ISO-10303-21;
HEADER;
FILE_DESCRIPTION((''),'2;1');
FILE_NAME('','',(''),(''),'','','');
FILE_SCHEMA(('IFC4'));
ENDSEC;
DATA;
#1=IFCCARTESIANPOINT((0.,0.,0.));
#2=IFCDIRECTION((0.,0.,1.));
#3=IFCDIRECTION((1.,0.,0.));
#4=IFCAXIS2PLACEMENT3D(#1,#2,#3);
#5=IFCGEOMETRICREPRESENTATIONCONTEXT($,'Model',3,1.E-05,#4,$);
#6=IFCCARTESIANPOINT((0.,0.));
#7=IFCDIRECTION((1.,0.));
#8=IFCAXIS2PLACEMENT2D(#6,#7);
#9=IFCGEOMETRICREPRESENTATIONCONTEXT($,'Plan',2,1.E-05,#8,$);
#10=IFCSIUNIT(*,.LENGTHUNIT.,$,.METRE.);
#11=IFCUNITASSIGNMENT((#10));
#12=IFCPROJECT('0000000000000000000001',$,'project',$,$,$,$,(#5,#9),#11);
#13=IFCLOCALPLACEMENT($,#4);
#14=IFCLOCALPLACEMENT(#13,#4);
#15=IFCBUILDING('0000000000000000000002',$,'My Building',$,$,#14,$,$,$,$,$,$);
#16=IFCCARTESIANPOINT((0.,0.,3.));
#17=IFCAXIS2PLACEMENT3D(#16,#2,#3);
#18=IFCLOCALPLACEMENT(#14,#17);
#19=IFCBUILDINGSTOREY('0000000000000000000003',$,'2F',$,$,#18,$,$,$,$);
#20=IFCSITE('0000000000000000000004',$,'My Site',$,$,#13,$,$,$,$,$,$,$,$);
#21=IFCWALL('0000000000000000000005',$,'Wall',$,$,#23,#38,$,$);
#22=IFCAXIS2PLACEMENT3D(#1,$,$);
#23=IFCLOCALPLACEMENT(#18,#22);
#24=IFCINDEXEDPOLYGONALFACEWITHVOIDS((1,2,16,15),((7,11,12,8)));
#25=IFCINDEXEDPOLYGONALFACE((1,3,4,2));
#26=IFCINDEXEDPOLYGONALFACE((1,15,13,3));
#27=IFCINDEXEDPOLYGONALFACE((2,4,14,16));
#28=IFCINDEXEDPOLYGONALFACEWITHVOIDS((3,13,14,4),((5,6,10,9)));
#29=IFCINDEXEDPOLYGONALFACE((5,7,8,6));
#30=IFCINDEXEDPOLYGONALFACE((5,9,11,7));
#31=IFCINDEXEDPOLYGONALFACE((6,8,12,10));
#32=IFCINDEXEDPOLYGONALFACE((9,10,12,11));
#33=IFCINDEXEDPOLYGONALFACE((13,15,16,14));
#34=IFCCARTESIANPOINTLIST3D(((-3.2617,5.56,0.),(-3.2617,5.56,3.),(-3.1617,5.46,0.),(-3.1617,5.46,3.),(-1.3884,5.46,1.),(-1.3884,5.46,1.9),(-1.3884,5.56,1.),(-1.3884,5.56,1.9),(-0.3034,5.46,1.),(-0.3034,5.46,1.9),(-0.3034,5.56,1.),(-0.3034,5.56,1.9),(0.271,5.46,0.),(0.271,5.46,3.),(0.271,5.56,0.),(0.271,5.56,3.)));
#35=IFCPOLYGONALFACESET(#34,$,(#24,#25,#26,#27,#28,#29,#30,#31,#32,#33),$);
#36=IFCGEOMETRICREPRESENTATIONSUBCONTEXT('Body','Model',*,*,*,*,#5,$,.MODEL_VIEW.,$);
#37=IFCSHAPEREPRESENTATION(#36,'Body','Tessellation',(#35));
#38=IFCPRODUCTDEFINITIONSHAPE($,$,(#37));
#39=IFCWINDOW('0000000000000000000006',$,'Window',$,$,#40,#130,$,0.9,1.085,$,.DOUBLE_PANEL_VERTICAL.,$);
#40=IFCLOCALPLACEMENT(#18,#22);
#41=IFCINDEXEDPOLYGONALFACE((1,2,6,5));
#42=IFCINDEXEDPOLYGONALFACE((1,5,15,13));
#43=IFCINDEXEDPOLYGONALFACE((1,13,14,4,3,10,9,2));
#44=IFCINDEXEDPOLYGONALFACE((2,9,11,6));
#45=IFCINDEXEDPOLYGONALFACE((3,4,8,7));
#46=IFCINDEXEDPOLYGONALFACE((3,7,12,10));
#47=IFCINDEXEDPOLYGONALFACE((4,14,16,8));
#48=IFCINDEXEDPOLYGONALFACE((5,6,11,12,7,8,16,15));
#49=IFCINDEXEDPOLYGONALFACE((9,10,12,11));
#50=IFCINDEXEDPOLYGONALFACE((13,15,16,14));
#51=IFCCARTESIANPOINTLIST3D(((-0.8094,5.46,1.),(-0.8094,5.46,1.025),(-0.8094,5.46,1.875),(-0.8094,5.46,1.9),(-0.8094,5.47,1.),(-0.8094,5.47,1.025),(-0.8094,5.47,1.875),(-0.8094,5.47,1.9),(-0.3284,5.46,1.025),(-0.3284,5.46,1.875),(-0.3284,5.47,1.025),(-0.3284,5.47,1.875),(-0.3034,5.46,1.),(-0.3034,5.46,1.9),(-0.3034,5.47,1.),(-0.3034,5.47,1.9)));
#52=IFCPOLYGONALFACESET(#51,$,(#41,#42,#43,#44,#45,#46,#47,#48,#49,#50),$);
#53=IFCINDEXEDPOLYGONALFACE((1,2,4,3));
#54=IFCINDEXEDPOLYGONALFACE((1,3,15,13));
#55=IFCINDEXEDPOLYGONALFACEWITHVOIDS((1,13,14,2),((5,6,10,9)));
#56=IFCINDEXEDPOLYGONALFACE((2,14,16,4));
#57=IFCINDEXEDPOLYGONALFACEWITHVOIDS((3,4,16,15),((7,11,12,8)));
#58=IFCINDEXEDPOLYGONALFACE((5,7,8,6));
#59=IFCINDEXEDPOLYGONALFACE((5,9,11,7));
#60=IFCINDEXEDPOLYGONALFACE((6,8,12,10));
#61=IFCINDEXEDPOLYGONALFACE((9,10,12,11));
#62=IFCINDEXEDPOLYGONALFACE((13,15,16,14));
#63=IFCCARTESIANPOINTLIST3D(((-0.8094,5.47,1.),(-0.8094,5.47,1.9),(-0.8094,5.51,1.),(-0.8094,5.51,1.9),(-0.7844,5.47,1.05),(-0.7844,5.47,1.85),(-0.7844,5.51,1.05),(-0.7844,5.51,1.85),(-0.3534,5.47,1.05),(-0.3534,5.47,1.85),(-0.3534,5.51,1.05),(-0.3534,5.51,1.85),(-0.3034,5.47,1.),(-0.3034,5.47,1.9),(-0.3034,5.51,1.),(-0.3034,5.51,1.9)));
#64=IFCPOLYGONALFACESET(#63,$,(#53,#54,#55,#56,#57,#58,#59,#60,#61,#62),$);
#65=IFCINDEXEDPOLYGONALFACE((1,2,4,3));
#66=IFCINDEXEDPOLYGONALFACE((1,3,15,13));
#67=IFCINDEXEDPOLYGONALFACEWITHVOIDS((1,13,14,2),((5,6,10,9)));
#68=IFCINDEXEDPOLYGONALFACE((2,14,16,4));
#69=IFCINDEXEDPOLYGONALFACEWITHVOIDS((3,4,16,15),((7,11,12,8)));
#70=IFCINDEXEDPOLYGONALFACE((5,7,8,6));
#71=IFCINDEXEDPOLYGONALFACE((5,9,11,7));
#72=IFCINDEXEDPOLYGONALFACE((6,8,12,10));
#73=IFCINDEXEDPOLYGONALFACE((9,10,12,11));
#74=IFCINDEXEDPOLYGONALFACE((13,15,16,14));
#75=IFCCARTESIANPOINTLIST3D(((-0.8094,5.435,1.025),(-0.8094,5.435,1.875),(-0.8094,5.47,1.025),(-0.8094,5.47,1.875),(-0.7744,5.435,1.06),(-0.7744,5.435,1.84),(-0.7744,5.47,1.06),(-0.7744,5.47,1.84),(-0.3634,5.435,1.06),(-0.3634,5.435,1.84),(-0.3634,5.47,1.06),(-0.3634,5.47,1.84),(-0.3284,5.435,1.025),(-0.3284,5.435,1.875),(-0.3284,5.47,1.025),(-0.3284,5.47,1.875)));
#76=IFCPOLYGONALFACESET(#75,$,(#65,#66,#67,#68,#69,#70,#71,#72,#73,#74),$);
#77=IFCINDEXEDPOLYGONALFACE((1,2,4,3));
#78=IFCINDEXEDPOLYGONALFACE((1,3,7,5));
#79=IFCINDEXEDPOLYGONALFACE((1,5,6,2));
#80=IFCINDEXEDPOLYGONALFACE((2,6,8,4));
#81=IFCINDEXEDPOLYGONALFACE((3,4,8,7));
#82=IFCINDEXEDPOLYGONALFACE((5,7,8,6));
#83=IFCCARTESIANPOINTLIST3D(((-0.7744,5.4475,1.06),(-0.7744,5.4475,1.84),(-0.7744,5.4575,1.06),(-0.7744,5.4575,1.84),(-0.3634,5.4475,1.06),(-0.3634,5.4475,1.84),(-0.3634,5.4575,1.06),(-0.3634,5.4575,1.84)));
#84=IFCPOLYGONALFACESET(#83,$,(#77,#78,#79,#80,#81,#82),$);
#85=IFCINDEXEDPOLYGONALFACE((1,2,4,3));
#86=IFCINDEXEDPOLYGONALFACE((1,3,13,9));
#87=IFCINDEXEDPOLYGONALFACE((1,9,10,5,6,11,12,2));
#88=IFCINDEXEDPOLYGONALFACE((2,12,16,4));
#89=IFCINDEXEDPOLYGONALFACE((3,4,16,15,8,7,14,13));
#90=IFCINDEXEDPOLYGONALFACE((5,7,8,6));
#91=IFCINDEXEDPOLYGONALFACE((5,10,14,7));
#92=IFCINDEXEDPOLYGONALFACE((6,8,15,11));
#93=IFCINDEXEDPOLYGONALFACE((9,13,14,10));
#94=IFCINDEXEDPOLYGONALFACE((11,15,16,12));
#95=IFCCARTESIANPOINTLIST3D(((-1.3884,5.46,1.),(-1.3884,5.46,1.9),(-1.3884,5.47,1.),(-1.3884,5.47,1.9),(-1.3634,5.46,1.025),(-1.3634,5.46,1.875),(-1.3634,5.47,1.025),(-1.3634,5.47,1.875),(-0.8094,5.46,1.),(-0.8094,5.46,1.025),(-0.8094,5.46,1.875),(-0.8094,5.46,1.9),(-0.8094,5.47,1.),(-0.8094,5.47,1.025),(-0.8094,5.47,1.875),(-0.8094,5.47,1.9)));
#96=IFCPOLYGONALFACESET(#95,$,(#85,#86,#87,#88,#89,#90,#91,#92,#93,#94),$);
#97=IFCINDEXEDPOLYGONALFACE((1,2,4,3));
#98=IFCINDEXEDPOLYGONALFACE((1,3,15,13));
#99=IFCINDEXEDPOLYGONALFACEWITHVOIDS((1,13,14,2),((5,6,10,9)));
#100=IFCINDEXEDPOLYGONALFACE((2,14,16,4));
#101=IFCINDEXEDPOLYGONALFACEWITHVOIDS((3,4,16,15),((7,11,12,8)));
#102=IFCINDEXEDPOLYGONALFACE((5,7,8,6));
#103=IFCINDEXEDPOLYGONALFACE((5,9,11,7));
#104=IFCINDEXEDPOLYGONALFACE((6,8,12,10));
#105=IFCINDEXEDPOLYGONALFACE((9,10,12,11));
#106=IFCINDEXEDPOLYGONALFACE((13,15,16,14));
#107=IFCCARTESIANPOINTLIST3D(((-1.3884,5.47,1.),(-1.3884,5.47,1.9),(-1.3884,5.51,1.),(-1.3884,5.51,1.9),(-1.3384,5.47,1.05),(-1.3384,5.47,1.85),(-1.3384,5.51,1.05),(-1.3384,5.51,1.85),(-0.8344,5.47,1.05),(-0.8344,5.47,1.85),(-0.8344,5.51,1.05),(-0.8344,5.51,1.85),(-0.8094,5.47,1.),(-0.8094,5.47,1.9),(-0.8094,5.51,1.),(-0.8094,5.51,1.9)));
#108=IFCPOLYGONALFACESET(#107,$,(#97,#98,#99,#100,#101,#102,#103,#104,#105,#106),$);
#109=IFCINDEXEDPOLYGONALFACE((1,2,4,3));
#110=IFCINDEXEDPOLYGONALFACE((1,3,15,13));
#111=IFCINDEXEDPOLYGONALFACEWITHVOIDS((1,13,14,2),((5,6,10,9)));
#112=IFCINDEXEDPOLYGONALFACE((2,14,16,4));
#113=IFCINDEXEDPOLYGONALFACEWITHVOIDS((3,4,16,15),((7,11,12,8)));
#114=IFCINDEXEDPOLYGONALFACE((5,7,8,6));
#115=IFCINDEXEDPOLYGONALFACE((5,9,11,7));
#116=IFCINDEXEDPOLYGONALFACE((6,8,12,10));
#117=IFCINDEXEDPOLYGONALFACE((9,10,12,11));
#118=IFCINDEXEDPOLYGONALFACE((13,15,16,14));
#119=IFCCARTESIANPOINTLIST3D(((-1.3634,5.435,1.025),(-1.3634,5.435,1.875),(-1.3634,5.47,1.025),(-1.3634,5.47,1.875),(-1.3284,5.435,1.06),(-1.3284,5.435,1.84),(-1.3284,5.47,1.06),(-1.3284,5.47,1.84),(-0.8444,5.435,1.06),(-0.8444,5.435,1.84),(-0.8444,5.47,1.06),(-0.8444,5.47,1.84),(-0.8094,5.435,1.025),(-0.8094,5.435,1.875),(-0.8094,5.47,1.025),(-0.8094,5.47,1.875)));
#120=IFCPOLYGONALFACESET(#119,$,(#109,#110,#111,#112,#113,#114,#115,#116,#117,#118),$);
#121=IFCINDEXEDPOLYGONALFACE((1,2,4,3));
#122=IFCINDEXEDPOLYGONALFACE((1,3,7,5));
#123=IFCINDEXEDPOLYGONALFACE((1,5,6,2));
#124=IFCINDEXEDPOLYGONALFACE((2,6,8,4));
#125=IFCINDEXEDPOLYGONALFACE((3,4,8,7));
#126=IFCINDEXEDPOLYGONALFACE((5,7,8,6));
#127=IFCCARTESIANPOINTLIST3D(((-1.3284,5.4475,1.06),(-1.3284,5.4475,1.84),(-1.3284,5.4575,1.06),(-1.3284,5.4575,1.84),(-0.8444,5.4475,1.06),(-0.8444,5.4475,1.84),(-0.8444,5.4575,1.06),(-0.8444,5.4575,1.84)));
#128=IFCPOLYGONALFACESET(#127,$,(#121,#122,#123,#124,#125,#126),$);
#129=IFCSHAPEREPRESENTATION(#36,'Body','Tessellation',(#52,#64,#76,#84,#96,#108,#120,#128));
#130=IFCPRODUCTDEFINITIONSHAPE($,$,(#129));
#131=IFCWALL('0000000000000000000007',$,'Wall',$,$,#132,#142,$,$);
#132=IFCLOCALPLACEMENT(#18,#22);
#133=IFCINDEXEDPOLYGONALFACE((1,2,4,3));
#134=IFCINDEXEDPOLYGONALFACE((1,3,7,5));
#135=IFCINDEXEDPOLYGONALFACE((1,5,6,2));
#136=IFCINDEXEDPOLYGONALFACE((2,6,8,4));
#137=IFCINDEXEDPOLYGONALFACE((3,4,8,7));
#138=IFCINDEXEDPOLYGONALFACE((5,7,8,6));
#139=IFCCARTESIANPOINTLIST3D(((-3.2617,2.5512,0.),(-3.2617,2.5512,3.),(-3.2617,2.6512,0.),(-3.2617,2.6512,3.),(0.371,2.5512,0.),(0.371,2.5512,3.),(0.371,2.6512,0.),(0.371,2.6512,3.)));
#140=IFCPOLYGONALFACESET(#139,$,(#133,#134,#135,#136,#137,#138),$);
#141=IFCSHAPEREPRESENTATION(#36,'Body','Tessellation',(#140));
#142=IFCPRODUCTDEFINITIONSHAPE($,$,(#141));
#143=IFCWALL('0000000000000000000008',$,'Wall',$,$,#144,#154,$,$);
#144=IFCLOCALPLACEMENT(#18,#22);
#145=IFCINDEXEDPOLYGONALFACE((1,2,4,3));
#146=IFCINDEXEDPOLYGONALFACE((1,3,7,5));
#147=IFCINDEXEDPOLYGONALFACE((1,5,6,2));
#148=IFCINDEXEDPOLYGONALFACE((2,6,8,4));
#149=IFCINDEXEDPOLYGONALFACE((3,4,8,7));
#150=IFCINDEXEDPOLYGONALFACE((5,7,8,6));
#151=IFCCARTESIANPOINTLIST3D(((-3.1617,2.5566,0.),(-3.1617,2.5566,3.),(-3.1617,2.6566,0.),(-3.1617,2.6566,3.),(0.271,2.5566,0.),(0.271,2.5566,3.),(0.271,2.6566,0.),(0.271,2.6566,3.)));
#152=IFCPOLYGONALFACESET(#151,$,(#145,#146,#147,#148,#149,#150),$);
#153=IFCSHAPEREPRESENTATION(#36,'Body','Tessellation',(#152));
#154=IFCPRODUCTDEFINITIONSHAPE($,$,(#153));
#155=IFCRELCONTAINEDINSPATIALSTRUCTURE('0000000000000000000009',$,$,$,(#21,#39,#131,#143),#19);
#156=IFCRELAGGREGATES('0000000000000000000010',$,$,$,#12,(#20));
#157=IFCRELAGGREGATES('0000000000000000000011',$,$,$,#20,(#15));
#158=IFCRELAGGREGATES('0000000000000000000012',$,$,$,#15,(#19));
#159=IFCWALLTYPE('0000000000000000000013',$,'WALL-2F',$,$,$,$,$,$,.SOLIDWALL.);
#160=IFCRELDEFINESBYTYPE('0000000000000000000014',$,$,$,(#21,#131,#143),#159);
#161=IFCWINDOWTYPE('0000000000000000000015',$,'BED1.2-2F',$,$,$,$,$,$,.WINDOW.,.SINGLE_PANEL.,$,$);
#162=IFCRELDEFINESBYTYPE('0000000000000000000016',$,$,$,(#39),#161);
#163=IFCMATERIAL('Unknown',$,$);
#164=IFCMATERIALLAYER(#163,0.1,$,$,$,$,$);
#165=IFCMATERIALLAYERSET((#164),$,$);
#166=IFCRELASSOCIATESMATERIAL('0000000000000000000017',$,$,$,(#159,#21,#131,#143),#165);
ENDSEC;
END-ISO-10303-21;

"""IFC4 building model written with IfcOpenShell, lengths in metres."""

from ifc_helpers import new_model, entity, si_unit, frame, origin_with_axes, origin_2d_with_axis, place, context, subcontext, project, spatial, line, indexed_curve, outline, extrude, shape, source, transform, mapped, material, layer, layer_set, layer_usage, type_object, type_shapes, element, fill, save


model = new_model("IFC4")

# Units and contexts
model_context = context("Model", 3, precision=1e-05, world=origin_with_axes())
plan_context = context("Plan", 2, precision=1e-05, world=origin_2d_with_axis())
body_context_1 = subcontext(model_context, "Body", "Model", "MODEL_VIEW")
body_context_2 = subcontext(plan_context, "Body", "Plan", "PLAN_VIEW")
ifc_project = project(units=[si_unit("LENGTHUNIT", "METRE")], contexts=[model_context, plan_context])

# Site, building, storey
site_placement = place(None, origin_with_axes())
site = spatial("IfcSite", under=ifc_project, at=site_placement, Name="My Site")
building_placement = place(site_placement, origin_with_axes())
building = spatial("IfcBuilding", under=site, at=building_placement, Name="My Building")
storey_placement = place(building_placement, frame((0.0, 0.0, 3.0), z_axis=(0.0, 0.0, 1.0), x_axis=(1.0, 0.0, 0.0)))
storey = spatial("IfcBuildingStorey", under=building, at=storey_placement, Name="2F")

# Shared definitions
ifc_material = material(Name="Unknown")

# Shared definitions
ifc_layer_1 = layer(ifc_material, 0.1)
ifc_layer_set_1 = layer_set([ifc_layer_1])
wall_type = type_object("IfcWallType", Name="WALL-2F", PredefinedType="SOLIDWALL", material=ifc_layer_set_1)

# Wall, opening, window
ifc_layer_usage_1 = layer_usage(ifc_layer_set_1, "AXIS2", "POSITIVE", 0.0)
wall_1_placement = place(storey_placement, frame((0.371, 5.56, 0.0), z_axis=(0.0, 0.0, 1.0), x_axis=(-1.0, 0.0, 0.0)))
wall_1 = element("IfcWall", 1, at=wall_1_placement, inside=storey, type_object=wall_type, material=ifc_layer_usage_1, Name="Wall", context=body_context_1, shape_type="SweptSolid", body=[
    extrude(outline(indexed_curve([(0.1, 0.0), (0.1, 0.1), (3.5327, 0.1), (3.6327, 0.0)], segments=[line(1, 2, 3, 4, 1)])), origin_with_axes(), (0.0, 0.0, 1.0), 3.0),
])
shared_shape_1 = source(origin_with_axes(), body_context_1, "Body", "SweptSolid", [
    extrude(outline(indexed_curve([(0.0, 0.0), (1.085, 0.0), (1.085, 0.9), (0.0, 0.9)], segments=[line(1, 2, 3, 4, 1)])), frame((0.0, -0.6, 0.0), z_axis=(0.0, -1.0, 0.0), x_axis=(1.0, 0.0, 0.0)), (0.0, 0.0, -1.0), 1.2),
])
opening_1_placement = place(wall_1_placement, frame((0.6745, 0.0, 1.0), z_axis=(0.0, 0.0, 1.0), x_axis=(1.0, 0.0, 0.0)))
opening_1 = element("IfcOpeningElement", 2, at=opening_1_placement, cuts=wall_1, PredefinedType="OPENING", context=body_context_1, shape_type="MappedRepresentation", body=[
    mapped(shared_shape_1, transform((0.0, 0.0, 0.0), x_axis=(1.0, 0.0, 0.0), y_axis=(0.0, 1.0, 0.0), z_axis=(0.0, 0.0, 1.0), scale=1.0)),
])
window_type_1 = type_object("IfcWindowType", Name="BED1.2-2F", PartitioningType="SINGLE_PANEL", PredefinedType="WINDOW")
shared_shape_2 = source(origin_with_axes(), body_context_1, "Body", "SweptSolid", [
    extrude(outline(indexed_curve([(0.5059, 0.0), (0.0, 0.0), (0.0, 0.9), (0.5059, 0.9), (0.5059, 0.875), (0.025, 0.875), (0.025, 0.025), (0.5059, 0.025)], segments=[line(1, 2, 3, 4, 5, 6, 7, 8, 1)])), frame((0.0, 0.09, 0.0), z_axis=(0.0, -1.0, 0.0), x_axis=(1.0, 0.0, 0.0)), (0.0, 0.0, -1.0), 0.01),
    extrude(outline(indexed_curve([(0.0, 0.0), (0.5059, 0.0), (0.5059, 0.9), (0.0, 0.9)], segments=[line(1, 2, 3, 4, 1)]), holes=[indexed_curve([(0.05, 0.05), (0.4809, 0.05), (0.4809, 0.85), (0.05, 0.85)], segments=[line(1, 2, 3, 4, 1)])]), frame((0.0, 0.05, 0.0), z_axis=(0.0, -1.0, 0.0), x_axis=(1.0, 0.0, 0.0)), (0.0, 0.0, -1.0), 0.04),
    extrude(outline(indexed_curve([(0.0, 0.0), (0.4809, 0.0), (0.4809, 0.85), (0.0, 0.85)], segments=[line(1, 2, 3, 4, 1)]), holes=[indexed_curve([(0.035, 0.035), (0.4459, 0.035), (0.4459, 0.815), (0.035, 0.815)], segments=[line(1, 2, 3, 4, 1)])]), frame((0.025, 0.09, 0.025), z_axis=(0.0, -1.0, 0.0), x_axis=(1.0, 0.0, 0.0)), (0.0, 0.0, -1.0), 0.035),
    extrude(outline(indexed_curve([(0.035, 0.035), (0.4459, 0.035), (0.4459, 0.815), (0.035, 0.815)], segments=[line(1, 2, 3, 4, 1)])), frame((0.025, 0.1025, 0.025), z_axis=(0.0, -1.0, 0.0), x_axis=(1.0, 0.0, 0.0)), (0.0, 0.0, -1.0), 0.01),
    extrude(outline(indexed_curve([(0.0, 0.9), (0.579, 0.9), (0.579, 0.0), (0.0, 0.0), (0.0, 0.025), (0.554, 0.025), (0.554, 0.875), (0.0, 0.875)], segments=[line(1, 2, 3, 4, 5, 6, 7, 8, 1)])), frame((0.5059, 0.09, 0.0), z_axis=(0.0, -1.0, 0.0), x_axis=(1.0, 0.0, 0.0)), (0.0, 0.0, -1.0), 0.01),
    extrude(outline(indexed_curve([(0.0, 0.0), (0.579, 0.0), (0.579, 0.9), (0.0, 0.9)], segments=[line(1, 2, 3, 4, 1)]), holes=[indexed_curve([(0.025, 0.05), (0.529, 0.05), (0.529, 0.85), (0.025, 0.85)], segments=[line(1, 2, 3, 4, 1)])]), frame((0.5059, 0.05, 0.0), z_axis=(0.0, -1.0, 0.0), x_axis=(1.0, 0.0, 0.0)), (0.0, 0.0, -1.0), 0.04),
    extrude(outline(indexed_curve([(0.0, 0.0), (0.554, 0.0), (0.554, 0.85), (0.0, 0.85)], segments=[line(1, 2, 3, 4, 1)]), holes=[indexed_curve([(0.035, 0.035), (0.519, 0.035), (0.519, 0.815), (0.035, 0.815)], segments=[line(1, 2, 3, 4, 1)])]), frame((0.5059, 0.09, 0.025), z_axis=(0.0, -1.0, 0.0), x_axis=(1.0, 0.0, 0.0)), (0.0, 0.0, -1.0), 0.035),
    extrude(outline(indexed_curve([(0.035, 0.035), (0.519, 0.035), (0.519, 0.815), (0.035, 0.815)], segments=[line(1, 2, 3, 4, 1)])), frame((0.5059, 0.1025, 0.025), z_axis=(0.0, -1.0, 0.0), x_axis=(1.0, 0.0, 0.0)), (0.0, 0.0, -1.0), 0.01),
])
shared_shape_3 = source(origin_with_axes(), body_context_2, "Body", "Curve2D", [
    entity("IfcIndexedPolyCurve", entity("IfcCartesianPointList2D", [[0.05, 0.05], [0.4809, 0.05]])),
    entity("IfcIndexedPolyCurve", entity("IfcCartesianPointList2D", [[0.0, 0.1], [0.025, 0.1], [0.025, 0.09], [0.05, 0.09], [0.05, 0.05], [0.0, 0.05]]), [entity("IfcLineIndex", [1, 2, 3, 4, 5, 6, 1])]),
    entity("IfcIndexedPolyCurve", entity("IfcCartesianPointList2D", [[0.5059, 0.1], [0.5059, 0.1], [0.5059, 0.09], [0.4809, 0.09], [0.4809, 0.05], [0.5059, 0.05]])),
    entity("IfcIndexedPolyCurve", entity("IfcCartesianPointList2D", [[0.025, 0.09], [0.06, 0.09], [0.06, 0.125], [0.025, 0.125]]), [entity("IfcLineIndex", [1, 2, 3, 4, 1])]),
    entity("IfcIndexedPolyCurve", entity("IfcCartesianPointList2D", [[0.5059, 0.09], [0.4709, 0.09], [0.4709, 0.125], [0.5059, 0.125]]), [entity("IfcLineIndex", [1, 2, 3, 4, 1])]),
    entity("IfcIndexedPolyCurve", entity("IfcCartesianPointList2D", [[0.06, 0.09], [0.4709, 0.09]])),
    entity("IfcIndexedPolyCurve", entity("IfcCartesianPointList2D", [[0.06, 0.125], [0.4709, 0.125]])),
    entity("IfcIndexedPolyCurve", entity("IfcCartesianPointList2D", [[0.06, 0.1075], [0.4709, 0.1075]])),
    entity("IfcIndexedPolyCurve", entity("IfcCartesianPointList2D", [[0.5309, 0.05], [1.035, 0.05]])),
    entity("IfcIndexedPolyCurve", entity("IfcCartesianPointList2D", [[0.5059, 0.1], [0.5059, 0.1], [0.5059, 0.09], [0.5309, 0.09], [0.5309, 0.05], [0.5059, 0.05]])),
    entity("IfcIndexedPolyCurve", entity("IfcCartesianPointList2D", [[1.085, 0.1], [1.06, 0.1], [1.06, 0.09], [1.035, 0.09], [1.035, 0.05], [1.085, 0.05]]), [entity("IfcLineIndex", [1, 2, 3, 4, 5, 6, 1])]),
    entity("IfcIndexedPolyCurve", entity("IfcCartesianPointList2D", [[0.5059, 0.09], [0.5409, 0.09], [0.5409, 0.125], [0.5059, 0.125]]), [entity("IfcLineIndex", [1, 2, 3, 4, 1])]),
    entity("IfcIndexedPolyCurve", entity("IfcCartesianPointList2D", [[1.06, 0.09], [1.025, 0.09], [1.025, 0.125], [1.06, 0.125]]), [entity("IfcLineIndex", [1, 2, 3, 4, 1])]),
    entity("IfcIndexedPolyCurve", entity("IfcCartesianPointList2D", [[0.5409, 0.09], [1.025, 0.09]])),
    entity("IfcIndexedPolyCurve", entity("IfcCartesianPointList2D", [[0.5409, 0.125], [1.025, 0.125]])),
    entity("IfcIndexedPolyCurve", entity("IfcCartesianPointList2D", [[0.5409, 0.1075], [1.025, 0.1075]])),
])
type_shapes(window_type_1, [shared_shape_2, shared_shape_3])
window_1_placement = place(opening_1_placement, frame((0.0, 0.0, 0.0), z_axis=(0.0, 0.0, 1.0), x_axis=(1.0, 0.0, 0.0)))
window_1 = element("IfcWindow", 3, at=window_1_placement, inside=storey, type_object=window_type_1, Name="Window", OverallHeight=0.9, OverallWidth=1.085, PartitioningType="DOUBLE_PANEL_VERTICAL", shapes=[
    shape(body_context_1, "Body", "MappedRepresentation", [mapped(shared_shape_2, transform((0.0, 0.0, 0.0), x_axis=(1.0, 0.0, 0.0), y_axis=(0.0, 1.0, 0.0), z_axis=(0.0, 0.0, 1.0), scale=1.0))]),
    shape(body_context_2, "Body", "MappedRepresentation", [mapped(shared_shape_3, transform((0.0, 0.0, 0.0), x_axis=(1.0, 0.0, 0.0), y_axis=(0.0, 1.0, 0.0), z_axis=(0.0, 0.0, 1.0), scale=1.0))]),
])
fill(opening_1, window_1)

# Walls
ifc_layer_usage_2 = layer_usage(ifc_layer_set_1, "AXIS2", "POSITIVE", 0.0)
wall_2_placement = place(storey_placement, frame((0.371, 2.6512, 0.0), z_axis=(0.0, 0.0, 1.0), x_axis=(-1.0, 0.0, 0.0)))
element("IfcWall", 4, at=wall_2_placement, inside=storey, type_object=wall_type, material=ifc_layer_usage_2, Name="Wall", context=body_context_1, shape_type="SweptSolid", body=[
    extrude(outline(indexed_curve([(0.0, 0.0), (0.0, 0.1), (3.6327, 0.1), (3.6327, 0.0)], segments=[line(1, 2, 3, 4, 1)])), origin_with_axes(), (0.0, 0.0, 1.0), 3.0),
])
ifc_layer_usage_3 = layer_usage(ifc_layer_set_1, "AXIS2", "POSITIVE", 0.0)
wall_3_placement = place(storey_placement, frame((0.271, 2.6566, 0.0), z_axis=(0.0, 0.0, 1.0), x_axis=(-1.0, 0.0, 0.0)))
element("IfcWall", 5, at=wall_3_placement, inside=storey, type_object=wall_type, material=ifc_layer_usage_3, Name="Wall", context=body_context_1, shape_type="SweptSolid", body=[
    extrude(outline(indexed_curve([(0.0, 0.0), (0.0, 0.1), (3.4327, 0.1), (3.4327, 0.0)], segments=[line(1, 2, 3, 4, 1)])), origin_with_axes(), (0.0, 0.0, 1.0), 3.0),
])

save(model, "model.ifc")
